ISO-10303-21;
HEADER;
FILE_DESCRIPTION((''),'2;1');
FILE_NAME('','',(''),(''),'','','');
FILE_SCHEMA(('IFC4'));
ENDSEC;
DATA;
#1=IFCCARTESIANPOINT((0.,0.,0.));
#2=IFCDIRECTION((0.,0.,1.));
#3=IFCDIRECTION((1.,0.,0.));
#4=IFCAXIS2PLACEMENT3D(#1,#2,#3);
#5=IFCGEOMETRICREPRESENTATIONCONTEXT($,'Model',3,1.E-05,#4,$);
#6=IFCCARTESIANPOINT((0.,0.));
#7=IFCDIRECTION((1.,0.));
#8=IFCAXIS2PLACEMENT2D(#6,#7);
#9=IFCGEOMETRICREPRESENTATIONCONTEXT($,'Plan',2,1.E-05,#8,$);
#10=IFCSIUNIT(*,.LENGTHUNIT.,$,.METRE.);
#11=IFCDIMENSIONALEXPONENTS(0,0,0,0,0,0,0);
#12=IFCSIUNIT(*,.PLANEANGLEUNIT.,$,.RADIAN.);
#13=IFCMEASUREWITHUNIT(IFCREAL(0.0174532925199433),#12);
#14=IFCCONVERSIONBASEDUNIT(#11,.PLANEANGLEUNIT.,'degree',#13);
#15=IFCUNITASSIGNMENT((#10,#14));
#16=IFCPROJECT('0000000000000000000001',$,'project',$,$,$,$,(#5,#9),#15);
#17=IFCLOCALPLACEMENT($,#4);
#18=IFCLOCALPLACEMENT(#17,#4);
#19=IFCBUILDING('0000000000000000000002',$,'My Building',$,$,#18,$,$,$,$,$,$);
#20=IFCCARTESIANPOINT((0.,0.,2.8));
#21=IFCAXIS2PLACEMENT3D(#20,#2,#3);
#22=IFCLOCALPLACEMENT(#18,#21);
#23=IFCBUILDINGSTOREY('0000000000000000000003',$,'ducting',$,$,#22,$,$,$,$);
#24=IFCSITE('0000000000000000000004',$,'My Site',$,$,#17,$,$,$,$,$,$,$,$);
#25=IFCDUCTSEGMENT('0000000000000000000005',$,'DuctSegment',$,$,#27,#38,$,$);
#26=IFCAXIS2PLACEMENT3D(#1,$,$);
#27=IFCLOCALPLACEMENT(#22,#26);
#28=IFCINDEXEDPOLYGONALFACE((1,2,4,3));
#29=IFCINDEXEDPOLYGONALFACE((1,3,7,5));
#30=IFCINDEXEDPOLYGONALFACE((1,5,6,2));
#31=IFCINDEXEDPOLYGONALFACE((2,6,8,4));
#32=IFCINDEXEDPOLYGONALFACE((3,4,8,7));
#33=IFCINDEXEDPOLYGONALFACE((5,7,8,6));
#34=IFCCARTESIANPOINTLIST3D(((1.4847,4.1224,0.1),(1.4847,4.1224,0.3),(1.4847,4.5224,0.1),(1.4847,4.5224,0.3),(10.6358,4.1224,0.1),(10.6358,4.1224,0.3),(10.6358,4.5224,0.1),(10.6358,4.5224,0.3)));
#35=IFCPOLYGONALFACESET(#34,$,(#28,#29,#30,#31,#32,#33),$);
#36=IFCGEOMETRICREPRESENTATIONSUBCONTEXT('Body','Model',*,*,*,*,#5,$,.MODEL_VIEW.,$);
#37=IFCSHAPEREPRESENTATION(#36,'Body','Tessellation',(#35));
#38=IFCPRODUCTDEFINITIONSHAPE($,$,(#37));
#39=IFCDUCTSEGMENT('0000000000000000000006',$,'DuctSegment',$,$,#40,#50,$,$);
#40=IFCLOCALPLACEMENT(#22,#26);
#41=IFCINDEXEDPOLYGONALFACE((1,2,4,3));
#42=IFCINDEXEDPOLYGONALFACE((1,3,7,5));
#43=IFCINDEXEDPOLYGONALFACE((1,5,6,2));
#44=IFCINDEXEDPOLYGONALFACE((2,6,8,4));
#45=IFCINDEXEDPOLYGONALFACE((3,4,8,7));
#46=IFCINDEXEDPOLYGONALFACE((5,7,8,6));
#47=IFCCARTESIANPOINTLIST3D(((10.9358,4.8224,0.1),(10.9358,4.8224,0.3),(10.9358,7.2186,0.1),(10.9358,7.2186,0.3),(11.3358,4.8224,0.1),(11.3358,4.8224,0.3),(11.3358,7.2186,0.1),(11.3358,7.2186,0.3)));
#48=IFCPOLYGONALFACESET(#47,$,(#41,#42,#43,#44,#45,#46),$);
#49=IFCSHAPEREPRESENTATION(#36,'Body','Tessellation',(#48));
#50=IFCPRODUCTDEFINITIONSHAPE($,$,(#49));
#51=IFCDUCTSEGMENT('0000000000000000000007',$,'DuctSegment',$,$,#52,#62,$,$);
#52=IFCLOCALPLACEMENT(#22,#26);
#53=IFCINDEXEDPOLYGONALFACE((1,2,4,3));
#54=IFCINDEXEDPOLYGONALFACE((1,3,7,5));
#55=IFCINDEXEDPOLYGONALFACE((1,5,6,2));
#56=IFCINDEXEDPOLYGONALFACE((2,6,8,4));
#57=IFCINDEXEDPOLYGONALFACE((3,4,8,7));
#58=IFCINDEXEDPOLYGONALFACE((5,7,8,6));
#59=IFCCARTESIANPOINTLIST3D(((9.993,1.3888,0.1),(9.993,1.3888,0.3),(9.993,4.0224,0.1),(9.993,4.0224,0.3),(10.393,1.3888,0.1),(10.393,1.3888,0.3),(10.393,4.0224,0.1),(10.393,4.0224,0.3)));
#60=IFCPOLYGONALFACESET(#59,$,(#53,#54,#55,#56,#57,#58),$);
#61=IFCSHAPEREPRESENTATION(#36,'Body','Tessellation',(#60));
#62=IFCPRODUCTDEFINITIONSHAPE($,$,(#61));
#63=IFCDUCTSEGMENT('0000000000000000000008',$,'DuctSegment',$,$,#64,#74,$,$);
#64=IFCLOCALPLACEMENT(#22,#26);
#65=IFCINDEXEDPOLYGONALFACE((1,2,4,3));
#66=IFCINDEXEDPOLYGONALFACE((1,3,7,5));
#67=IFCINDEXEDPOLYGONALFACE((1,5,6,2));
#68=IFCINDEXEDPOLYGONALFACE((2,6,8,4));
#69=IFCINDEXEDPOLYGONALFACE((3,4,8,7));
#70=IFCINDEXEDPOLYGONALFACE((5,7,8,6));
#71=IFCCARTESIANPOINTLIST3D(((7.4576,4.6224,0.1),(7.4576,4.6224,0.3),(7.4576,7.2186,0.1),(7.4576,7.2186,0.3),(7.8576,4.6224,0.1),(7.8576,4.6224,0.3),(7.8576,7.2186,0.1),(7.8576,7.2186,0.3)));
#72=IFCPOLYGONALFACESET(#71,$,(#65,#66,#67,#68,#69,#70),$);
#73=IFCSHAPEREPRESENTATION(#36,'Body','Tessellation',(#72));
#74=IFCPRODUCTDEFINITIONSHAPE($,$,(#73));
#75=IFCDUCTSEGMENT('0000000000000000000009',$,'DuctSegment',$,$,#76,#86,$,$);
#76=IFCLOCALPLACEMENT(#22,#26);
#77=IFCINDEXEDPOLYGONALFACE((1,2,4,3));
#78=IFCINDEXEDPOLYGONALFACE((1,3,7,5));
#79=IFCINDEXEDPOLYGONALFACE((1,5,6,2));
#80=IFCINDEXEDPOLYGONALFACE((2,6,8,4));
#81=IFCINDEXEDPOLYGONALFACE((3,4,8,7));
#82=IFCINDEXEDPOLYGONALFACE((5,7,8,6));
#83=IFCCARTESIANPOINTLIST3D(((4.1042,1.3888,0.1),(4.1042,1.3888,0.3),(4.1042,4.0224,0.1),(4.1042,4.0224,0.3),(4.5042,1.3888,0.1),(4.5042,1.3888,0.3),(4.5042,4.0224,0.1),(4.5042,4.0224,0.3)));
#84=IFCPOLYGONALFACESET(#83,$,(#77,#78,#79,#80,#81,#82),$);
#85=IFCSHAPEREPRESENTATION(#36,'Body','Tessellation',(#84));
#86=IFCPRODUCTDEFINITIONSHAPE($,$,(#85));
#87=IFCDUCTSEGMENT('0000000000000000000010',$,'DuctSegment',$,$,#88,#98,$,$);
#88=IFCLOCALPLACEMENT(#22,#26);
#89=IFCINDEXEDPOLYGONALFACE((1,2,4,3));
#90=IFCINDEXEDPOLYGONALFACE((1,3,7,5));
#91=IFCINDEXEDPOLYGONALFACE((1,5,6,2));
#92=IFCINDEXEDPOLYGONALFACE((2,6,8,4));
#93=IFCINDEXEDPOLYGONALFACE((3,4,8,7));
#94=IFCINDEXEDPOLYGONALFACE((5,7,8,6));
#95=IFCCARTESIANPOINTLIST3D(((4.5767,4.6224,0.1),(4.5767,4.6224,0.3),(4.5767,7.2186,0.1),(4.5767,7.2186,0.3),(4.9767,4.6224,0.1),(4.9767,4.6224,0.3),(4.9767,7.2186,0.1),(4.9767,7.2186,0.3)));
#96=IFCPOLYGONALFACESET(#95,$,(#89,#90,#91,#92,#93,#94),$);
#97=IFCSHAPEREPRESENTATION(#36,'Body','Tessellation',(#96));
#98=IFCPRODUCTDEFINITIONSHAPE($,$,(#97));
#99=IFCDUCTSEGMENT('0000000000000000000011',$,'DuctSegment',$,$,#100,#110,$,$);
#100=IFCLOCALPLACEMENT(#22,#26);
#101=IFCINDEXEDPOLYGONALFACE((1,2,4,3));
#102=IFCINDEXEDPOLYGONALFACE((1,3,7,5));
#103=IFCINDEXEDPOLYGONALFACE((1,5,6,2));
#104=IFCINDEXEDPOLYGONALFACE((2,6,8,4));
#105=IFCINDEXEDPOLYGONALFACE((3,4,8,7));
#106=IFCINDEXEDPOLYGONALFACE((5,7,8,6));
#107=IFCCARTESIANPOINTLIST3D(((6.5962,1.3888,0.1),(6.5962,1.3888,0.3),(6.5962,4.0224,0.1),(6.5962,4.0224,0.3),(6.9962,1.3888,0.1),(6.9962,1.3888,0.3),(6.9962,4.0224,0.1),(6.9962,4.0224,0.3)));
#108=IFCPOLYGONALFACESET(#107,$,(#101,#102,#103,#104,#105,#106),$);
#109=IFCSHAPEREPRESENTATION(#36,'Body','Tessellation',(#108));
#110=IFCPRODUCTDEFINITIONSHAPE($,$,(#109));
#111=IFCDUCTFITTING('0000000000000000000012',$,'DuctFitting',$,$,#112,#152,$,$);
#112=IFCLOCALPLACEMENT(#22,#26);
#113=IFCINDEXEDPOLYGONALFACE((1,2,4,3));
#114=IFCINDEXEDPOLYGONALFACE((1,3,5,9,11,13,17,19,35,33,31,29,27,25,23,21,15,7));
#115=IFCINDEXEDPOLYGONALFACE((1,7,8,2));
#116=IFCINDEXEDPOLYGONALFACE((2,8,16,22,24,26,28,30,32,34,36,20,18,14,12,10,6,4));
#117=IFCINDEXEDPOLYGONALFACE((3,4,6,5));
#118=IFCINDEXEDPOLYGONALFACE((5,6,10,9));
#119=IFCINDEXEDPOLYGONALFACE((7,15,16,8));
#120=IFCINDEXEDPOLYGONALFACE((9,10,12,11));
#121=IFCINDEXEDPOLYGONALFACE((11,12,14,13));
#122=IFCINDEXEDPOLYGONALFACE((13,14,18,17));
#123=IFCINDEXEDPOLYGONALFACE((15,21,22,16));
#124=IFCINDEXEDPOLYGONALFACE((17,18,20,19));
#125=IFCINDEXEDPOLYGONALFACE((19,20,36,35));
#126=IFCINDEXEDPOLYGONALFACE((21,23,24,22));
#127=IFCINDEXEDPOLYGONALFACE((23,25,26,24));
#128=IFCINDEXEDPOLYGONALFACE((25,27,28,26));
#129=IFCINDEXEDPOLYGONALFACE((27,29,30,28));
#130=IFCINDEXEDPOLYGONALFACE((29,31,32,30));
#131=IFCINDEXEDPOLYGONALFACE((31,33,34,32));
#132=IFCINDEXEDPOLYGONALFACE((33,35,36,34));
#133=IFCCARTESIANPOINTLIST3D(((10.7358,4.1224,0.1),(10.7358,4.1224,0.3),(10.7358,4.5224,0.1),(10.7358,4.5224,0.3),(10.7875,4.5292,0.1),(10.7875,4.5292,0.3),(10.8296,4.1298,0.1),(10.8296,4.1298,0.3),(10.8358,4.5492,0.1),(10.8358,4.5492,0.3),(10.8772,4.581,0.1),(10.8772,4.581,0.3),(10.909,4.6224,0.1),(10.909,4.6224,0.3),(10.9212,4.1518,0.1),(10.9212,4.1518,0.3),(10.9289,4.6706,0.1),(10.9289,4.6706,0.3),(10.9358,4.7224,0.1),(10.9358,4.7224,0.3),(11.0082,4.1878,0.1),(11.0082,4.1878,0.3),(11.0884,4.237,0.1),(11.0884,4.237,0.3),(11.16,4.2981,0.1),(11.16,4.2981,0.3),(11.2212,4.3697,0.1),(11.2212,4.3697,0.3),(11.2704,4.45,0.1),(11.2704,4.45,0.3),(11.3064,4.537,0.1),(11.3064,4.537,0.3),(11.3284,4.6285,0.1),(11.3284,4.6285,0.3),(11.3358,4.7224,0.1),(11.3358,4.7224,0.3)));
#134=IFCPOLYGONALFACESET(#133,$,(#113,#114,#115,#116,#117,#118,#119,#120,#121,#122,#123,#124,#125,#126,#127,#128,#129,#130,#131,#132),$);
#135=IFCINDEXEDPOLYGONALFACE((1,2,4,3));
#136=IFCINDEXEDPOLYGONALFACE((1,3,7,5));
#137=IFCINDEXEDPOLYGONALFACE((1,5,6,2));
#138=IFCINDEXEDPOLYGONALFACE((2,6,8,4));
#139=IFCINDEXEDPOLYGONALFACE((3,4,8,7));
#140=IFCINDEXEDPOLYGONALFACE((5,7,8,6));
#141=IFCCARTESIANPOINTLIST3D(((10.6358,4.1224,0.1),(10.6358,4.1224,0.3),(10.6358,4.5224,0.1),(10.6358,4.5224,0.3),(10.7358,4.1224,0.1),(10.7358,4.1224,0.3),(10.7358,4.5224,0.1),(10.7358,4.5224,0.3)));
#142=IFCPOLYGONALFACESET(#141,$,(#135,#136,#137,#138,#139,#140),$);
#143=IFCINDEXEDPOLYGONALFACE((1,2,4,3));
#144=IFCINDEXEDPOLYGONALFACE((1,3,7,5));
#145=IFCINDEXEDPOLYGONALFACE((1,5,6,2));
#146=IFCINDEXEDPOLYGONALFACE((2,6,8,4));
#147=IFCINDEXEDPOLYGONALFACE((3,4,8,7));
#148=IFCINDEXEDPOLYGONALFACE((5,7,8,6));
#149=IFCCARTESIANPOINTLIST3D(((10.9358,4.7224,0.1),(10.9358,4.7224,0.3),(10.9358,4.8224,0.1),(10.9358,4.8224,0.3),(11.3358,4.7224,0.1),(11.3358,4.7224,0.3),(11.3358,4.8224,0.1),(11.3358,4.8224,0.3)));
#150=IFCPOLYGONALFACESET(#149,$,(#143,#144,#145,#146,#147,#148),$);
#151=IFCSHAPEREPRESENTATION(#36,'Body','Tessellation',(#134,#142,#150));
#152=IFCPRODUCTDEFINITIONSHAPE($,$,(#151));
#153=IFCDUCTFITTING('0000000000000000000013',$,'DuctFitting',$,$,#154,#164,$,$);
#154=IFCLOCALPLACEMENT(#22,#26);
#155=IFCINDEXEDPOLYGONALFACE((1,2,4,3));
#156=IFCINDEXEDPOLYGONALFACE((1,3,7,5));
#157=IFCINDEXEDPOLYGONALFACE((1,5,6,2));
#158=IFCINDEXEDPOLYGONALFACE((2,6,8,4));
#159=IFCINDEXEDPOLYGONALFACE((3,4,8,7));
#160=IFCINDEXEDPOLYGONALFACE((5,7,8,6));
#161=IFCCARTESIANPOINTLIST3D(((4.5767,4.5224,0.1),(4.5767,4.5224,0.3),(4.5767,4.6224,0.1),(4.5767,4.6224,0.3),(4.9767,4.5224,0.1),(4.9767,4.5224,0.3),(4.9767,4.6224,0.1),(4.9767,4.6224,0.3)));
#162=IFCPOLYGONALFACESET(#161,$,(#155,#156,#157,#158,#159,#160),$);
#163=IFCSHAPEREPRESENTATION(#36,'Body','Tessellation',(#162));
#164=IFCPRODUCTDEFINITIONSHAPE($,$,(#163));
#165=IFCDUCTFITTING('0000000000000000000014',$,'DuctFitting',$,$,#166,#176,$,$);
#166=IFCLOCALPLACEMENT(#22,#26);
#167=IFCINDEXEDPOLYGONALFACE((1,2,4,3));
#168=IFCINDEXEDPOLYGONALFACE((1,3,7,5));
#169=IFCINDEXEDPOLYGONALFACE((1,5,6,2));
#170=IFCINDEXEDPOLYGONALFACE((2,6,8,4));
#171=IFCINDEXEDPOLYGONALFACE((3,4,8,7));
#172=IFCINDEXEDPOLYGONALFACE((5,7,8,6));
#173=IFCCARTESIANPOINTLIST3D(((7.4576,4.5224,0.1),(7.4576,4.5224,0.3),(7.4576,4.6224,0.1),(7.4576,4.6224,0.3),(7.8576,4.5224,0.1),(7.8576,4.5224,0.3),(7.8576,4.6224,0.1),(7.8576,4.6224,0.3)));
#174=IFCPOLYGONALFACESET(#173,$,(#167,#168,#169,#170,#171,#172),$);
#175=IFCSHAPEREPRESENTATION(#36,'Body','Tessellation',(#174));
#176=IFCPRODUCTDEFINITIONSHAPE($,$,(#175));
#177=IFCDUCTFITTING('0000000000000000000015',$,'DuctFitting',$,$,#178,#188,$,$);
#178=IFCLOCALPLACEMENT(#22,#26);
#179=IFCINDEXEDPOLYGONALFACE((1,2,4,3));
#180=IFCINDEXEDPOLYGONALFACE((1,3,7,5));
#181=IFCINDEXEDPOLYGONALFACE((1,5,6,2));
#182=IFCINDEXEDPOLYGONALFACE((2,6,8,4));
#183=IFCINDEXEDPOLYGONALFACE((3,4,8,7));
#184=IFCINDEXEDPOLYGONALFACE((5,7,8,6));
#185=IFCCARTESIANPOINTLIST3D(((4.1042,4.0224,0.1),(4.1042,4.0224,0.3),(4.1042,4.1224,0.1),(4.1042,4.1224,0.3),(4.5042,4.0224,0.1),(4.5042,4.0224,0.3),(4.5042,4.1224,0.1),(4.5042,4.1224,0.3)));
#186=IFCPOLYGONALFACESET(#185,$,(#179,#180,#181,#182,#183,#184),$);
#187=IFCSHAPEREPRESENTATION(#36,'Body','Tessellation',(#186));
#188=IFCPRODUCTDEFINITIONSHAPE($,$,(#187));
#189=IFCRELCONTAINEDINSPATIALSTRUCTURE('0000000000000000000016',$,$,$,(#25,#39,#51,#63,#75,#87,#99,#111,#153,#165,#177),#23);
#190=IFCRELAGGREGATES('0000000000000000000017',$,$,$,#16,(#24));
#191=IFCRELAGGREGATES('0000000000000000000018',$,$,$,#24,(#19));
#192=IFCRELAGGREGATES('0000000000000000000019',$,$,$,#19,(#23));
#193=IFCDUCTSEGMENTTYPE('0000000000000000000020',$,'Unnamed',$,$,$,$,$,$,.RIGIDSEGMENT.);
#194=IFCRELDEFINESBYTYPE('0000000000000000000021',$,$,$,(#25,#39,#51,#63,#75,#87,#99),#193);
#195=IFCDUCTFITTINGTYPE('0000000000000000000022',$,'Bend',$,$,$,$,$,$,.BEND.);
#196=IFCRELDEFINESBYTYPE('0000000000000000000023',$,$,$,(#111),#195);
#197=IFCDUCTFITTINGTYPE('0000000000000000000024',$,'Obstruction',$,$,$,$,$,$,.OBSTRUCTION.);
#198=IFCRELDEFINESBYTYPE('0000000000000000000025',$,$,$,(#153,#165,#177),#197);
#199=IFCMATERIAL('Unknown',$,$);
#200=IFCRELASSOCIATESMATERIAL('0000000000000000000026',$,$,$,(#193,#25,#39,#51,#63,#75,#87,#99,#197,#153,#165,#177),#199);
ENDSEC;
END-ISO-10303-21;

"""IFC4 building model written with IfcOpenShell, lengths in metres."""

from ifc_helpers import new_model, entity, si_unit, converted_unit, frame, origin_with_axes, origin_2d_with_axis, place, context, subcontext, project, spatial, line, arc, indexed_curve, rectangle, outline, extrude, source, transform, mapped, material, material_profile, profile_set, profile_usage, type_object, type_shapes, element, save


model = new_model("IFC4")

# Units and contexts
model_context = context("Model", 3, precision=1e-05, world=origin_with_axes())
plan_context = context("Plan", 2, precision=1e-05, world=origin_2d_with_axis())
body_context = subcontext(model_context, "Body", "Model", "MODEL_VIEW")
ifc_project = project(units=[si_unit("LENGTHUNIT", "METRE"), converted_unit("PLANEANGLEUNIT", "degree", entity("IfcReal", 0.0174532925199433), si_unit("PLANEANGLEUNIT", "RADIAN"), dimensions=[0, 0, 0, 0, 0, 0, 0])], contexts=[model_context, plan_context])

# Site, building, storey
site_placement = place(None, origin_with_axes())
site = spatial("IfcSite", under=ifc_project, at=site_placement, Name="My Site")
building_placement = place(site_placement, origin_with_axes())
building = spatial("IfcBuilding", under=site, at=building_placement, Name="My Building")
storey_placement = place(building_placement, frame((0.0, 0.0, 2.8), z_axis=(0.0, 0.0, 1.0), x_axis=(1.0, 0.0, 0.0)))
storey = spatial("IfcBuildingStorey", under=building, at=storey_placement, Name="ducting")

# Duct segments
ifc_material = material(Name="Unknown")
ifc_material_profile_1 = material_profile(ifc_material, rectangle(XDim=0.4, YDim=0.2))
ifc_profile_set_1 = profile_set([ifc_material_profile_1])
ifc_profile_usage_1 = profile_usage(ifc_profile_set_1, cardinal=5)
duct_segment_type = type_object("IfcDuctSegmentType", Name="Unnamed", PredefinedType="RIGIDSEGMENT", material=ifc_profile_set_1)
duct_segment_1_placement = place(storey_placement, frame((1.4847, 4.3224, 0.2), z_axis=(1.0, 0.0, 0.0), x_axis=(0.0, 1.0, 0.0)))
element("IfcDuctSegment", 1, at=duct_segment_1_placement, inside=storey, type_object=duct_segment_type, material=ifc_profile_usage_1, Name="DuctSegment", context=body_context, shape_type="SweptSolid", body=[
    extrude(rectangle(XDim=0.4, YDim=0.2), origin_with_axes(), (0.0, 0.0, 1.0), 9.1511),
])
ifc_profile_usage_2 = profile_usage(ifc_profile_set_1, cardinal=5)
duct_segment_2_placement = place(storey_placement, frame((11.1358, 4.8224, 0.2), z_axis=(0.0, 1.0, 0.0), x_axis=(-1.0, 0.0, 0.0)))
element("IfcDuctSegment", 2, at=duct_segment_2_placement, inside=storey, type_object=duct_segment_type, material=ifc_profile_usage_2, Name="DuctSegment", context=body_context, shape_type="SweptSolid", body=[
    extrude(rectangle(XDim=0.4, YDim=0.2), origin_with_axes(), (0.0, 0.0, 1.0), 2.3962),
])
ifc_profile_usage_3 = profile_usage(ifc_profile_set_1, cardinal=5)
duct_segment_3_placement = place(storey_placement, frame((10.193, 1.3888, 0.2), z_axis=(0.0, 1.0, 0.0), x_axis=(1.0, 0.0, 0.0)))
element("IfcDuctSegment", 3, at=duct_segment_3_placement, inside=storey, type_object=duct_segment_type, material=ifc_profile_usage_3, Name="DuctSegment", context=body_context, shape_type="SweptSolid", body=[
    extrude(rectangle(XDim=0.4, YDim=0.2), origin_with_axes(), (0.0, 0.0, 1.0), 2.6336),
])
ifc_profile_usage_4 = profile_usage(ifc_profile_set_1, cardinal=5)
duct_segment_4_placement = place(storey_placement, frame((7.6576, 4.6224, 0.2), z_axis=(0.0, 1.0, 0.0), x_axis=(-1.0, 0.0, 0.0)))
element("IfcDuctSegment", 4, at=duct_segment_4_placement, inside=storey, type_object=duct_segment_type, material=ifc_profile_usage_4, Name="DuctSegment", context=body_context, shape_type="SweptSolid", body=[
    extrude(rectangle(XDim=0.4, YDim=0.2), origin_with_axes(), (0.0, 0.0, 1.0), 2.5962),
])
ifc_profile_usage_5 = profile_usage(ifc_profile_set_1, cardinal=5)
duct_segment_5_placement = place(storey_placement, frame((4.3042, 1.3888, 0.2), z_axis=(0.0, 1.0, 0.0), x_axis=(-1.0, 0.0, 0.0)))
element("IfcDuctSegment", 5, at=duct_segment_5_placement, inside=storey, type_object=duct_segment_type, material=ifc_profile_usage_5, Name="DuctSegment", context=body_context, shape_type="SweptSolid", body=[
    extrude(rectangle(XDim=0.4, YDim=0.2), origin_with_axes(), (0.0, 0.0, 1.0), 2.6336),
])
ifc_profile_usage_6 = profile_usage(ifc_profile_set_1, cardinal=5)
duct_segment_6_placement = place(storey_placement, frame((4.7767, 4.6224, 0.2), z_axis=(0.0, 1.0, 0.0), x_axis=(-1.0, 0.0, 0.0)))
element("IfcDuctSegment", 6, at=duct_segment_6_placement, inside=storey, type_object=duct_segment_type, material=ifc_profile_usage_6, Name="DuctSegment", context=body_context, shape_type="SweptSolid", body=[
    extrude(rectangle(XDim=0.4, YDim=0.2), origin_with_axes(), (0.0, 0.0, 1.0), 2.5962),
])
ifc_profile_usage_7 = profile_usage(ifc_profile_set_1, cardinal=5)
duct_segment_7_placement = place(storey_placement, frame((6.7962, 1.3888, 0.2), z_axis=(0.0, 1.0, 0.0), x_axis=(-1.0, 0.0, 0.0)))
element("IfcDuctSegment", 7, at=duct_segment_7_placement, inside=storey, type_object=duct_segment_type, material=ifc_profile_usage_7, Name="DuctSegment", context=body_context, shape_type="SweptSolid", body=[
    extrude(rectangle(XDim=0.4, YDim=0.2), origin_with_axes(), (0.0, 0.0, 1.0), 2.6336),
])

# Duct fittings
duct_fitting_type_1 = type_object("IfcDuctFittingType", Name="Bend", PredefinedType="BEND")
shared_shape = source(origin_with_axes(), body_context, "Body", "SweptSolid", [
    extrude(outline(indexed_curve([(0.2, 0.0), (0.2586, 0.1414), (0.4, 0.2), (0.4, 0.6), (-0.0243, 0.4243), (-0.2, 0.0)], segments=[arc(1, 2, 3), line(3, 4), arc(4, 5, 6), line(6, 1)])), frame((0.0, -0.1, 0.1), z_axis=(0.0, -1.0, 0.0), x_axis=(1.0, 0.0, 0.0)), (0.0, 0.0, -1.0), 0.2),
    extrude(rectangle(XDim=0.4, YDim=0.2), origin_with_axes(), (0.0, 0.0, 1.0), 0.1),
    extrude(rectangle(XDim=0.4, YDim=0.2), frame((0.4, 0.0, 0.5), z_axis=(1.0, 0.0, 0.0), x_axis=(0.0, 0.0, 1.0)), (0.0, 0.0, 1.0), 0.1),
])
type_shapes(duct_fitting_type_1, [shared_shape])
duct_fitting_1_placement = place(storey_placement, frame((10.6358, 4.3224, 0.2), z_axis=(1.0, 0.0, 0.0), x_axis=(0.0, 1.0, 0.0)))
element("IfcDuctFitting", 8, at=duct_fitting_1_placement, inside=storey, type_object=duct_fitting_type_1, Name="DuctFitting", context=body_context, shape_type="MappedRepresentation", body=[
    mapped(shared_shape, transform((0.0, 0.0, 0.0), x_axis=(1.0, 0.0, 0.0), y_axis=(0.0, 1.0, 0.0), z_axis=(0.0, 0.0, 1.0), scale=1.0)),
])
ifc_material_profile_2 = material_profile(ifc_material, rectangle(XDim=0.4, YDim=0.2))
ifc_profile_set_2 = profile_set([ifc_material_profile_2])
ifc_profile_usage_8 = profile_usage(ifc_profile_set_2, cardinal=5)
duct_fitting_type_2 = type_object("IfcDuctFittingType", Name="Obstruction", PredefinedType="OBSTRUCTION", material=ifc_profile_set_2)
duct_fitting_2_placement = place(storey_placement, frame((4.7767, 4.5224, 0.2), z_axis=(0.0, 1.0, 0.0), x_axis=(-1.0, 0.0, 0.0)))
element("IfcDuctFitting", 9, at=duct_fitting_2_placement, inside=storey, type_object=duct_fitting_type_2, material=ifc_profile_usage_8, Name="DuctFitting", context=body_context, shape_type="SweptSolid", body=[
    extrude(rectangle(XDim=0.4, YDim=0.2), origin_with_axes(), (0.0, 0.0, 1.0), 0.1),
])
ifc_profile_usage_9 = profile_usage(ifc_profile_set_2, cardinal=5)
duct_fitting_3_placement = place(storey_placement, frame((7.6576, 4.5224, 0.2), z_axis=(0.0, 1.0, 0.0), x_axis=(-1.0, 0.0, 0.0)))
element("IfcDuctFitting", 10, at=duct_fitting_3_placement, inside=storey, type_object=duct_fitting_type_2, material=ifc_profile_usage_9, Name="DuctFitting", context=body_context, shape_type="SweptSolid", body=[
    extrude(rectangle(XDim=0.4, YDim=0.2), origin_with_axes(), (0.0, 0.0, 1.0), 0.1),
])
ifc_profile_usage_10 = profile_usage(ifc_profile_set_2, cardinal=5)
duct_fitting_4_placement = place(storey_placement, frame((4.3042, 4.0224, 0.2), z_axis=(0.0, 1.0, 0.0), x_axis=(-1.0, 0.0, 0.0)))
element("IfcDuctFitting", 11, at=duct_fitting_4_placement, inside=storey, type_object=duct_fitting_type_2, material=ifc_profile_usage_10, Name="DuctFitting", context=body_context, shape_type="SweptSolid", body=[
    extrude(rectangle(XDim=0.4, YDim=0.2), origin_with_axes(), (0.0, 0.0, 1.0), 0.1),
])

save(model, "model.ifc")
